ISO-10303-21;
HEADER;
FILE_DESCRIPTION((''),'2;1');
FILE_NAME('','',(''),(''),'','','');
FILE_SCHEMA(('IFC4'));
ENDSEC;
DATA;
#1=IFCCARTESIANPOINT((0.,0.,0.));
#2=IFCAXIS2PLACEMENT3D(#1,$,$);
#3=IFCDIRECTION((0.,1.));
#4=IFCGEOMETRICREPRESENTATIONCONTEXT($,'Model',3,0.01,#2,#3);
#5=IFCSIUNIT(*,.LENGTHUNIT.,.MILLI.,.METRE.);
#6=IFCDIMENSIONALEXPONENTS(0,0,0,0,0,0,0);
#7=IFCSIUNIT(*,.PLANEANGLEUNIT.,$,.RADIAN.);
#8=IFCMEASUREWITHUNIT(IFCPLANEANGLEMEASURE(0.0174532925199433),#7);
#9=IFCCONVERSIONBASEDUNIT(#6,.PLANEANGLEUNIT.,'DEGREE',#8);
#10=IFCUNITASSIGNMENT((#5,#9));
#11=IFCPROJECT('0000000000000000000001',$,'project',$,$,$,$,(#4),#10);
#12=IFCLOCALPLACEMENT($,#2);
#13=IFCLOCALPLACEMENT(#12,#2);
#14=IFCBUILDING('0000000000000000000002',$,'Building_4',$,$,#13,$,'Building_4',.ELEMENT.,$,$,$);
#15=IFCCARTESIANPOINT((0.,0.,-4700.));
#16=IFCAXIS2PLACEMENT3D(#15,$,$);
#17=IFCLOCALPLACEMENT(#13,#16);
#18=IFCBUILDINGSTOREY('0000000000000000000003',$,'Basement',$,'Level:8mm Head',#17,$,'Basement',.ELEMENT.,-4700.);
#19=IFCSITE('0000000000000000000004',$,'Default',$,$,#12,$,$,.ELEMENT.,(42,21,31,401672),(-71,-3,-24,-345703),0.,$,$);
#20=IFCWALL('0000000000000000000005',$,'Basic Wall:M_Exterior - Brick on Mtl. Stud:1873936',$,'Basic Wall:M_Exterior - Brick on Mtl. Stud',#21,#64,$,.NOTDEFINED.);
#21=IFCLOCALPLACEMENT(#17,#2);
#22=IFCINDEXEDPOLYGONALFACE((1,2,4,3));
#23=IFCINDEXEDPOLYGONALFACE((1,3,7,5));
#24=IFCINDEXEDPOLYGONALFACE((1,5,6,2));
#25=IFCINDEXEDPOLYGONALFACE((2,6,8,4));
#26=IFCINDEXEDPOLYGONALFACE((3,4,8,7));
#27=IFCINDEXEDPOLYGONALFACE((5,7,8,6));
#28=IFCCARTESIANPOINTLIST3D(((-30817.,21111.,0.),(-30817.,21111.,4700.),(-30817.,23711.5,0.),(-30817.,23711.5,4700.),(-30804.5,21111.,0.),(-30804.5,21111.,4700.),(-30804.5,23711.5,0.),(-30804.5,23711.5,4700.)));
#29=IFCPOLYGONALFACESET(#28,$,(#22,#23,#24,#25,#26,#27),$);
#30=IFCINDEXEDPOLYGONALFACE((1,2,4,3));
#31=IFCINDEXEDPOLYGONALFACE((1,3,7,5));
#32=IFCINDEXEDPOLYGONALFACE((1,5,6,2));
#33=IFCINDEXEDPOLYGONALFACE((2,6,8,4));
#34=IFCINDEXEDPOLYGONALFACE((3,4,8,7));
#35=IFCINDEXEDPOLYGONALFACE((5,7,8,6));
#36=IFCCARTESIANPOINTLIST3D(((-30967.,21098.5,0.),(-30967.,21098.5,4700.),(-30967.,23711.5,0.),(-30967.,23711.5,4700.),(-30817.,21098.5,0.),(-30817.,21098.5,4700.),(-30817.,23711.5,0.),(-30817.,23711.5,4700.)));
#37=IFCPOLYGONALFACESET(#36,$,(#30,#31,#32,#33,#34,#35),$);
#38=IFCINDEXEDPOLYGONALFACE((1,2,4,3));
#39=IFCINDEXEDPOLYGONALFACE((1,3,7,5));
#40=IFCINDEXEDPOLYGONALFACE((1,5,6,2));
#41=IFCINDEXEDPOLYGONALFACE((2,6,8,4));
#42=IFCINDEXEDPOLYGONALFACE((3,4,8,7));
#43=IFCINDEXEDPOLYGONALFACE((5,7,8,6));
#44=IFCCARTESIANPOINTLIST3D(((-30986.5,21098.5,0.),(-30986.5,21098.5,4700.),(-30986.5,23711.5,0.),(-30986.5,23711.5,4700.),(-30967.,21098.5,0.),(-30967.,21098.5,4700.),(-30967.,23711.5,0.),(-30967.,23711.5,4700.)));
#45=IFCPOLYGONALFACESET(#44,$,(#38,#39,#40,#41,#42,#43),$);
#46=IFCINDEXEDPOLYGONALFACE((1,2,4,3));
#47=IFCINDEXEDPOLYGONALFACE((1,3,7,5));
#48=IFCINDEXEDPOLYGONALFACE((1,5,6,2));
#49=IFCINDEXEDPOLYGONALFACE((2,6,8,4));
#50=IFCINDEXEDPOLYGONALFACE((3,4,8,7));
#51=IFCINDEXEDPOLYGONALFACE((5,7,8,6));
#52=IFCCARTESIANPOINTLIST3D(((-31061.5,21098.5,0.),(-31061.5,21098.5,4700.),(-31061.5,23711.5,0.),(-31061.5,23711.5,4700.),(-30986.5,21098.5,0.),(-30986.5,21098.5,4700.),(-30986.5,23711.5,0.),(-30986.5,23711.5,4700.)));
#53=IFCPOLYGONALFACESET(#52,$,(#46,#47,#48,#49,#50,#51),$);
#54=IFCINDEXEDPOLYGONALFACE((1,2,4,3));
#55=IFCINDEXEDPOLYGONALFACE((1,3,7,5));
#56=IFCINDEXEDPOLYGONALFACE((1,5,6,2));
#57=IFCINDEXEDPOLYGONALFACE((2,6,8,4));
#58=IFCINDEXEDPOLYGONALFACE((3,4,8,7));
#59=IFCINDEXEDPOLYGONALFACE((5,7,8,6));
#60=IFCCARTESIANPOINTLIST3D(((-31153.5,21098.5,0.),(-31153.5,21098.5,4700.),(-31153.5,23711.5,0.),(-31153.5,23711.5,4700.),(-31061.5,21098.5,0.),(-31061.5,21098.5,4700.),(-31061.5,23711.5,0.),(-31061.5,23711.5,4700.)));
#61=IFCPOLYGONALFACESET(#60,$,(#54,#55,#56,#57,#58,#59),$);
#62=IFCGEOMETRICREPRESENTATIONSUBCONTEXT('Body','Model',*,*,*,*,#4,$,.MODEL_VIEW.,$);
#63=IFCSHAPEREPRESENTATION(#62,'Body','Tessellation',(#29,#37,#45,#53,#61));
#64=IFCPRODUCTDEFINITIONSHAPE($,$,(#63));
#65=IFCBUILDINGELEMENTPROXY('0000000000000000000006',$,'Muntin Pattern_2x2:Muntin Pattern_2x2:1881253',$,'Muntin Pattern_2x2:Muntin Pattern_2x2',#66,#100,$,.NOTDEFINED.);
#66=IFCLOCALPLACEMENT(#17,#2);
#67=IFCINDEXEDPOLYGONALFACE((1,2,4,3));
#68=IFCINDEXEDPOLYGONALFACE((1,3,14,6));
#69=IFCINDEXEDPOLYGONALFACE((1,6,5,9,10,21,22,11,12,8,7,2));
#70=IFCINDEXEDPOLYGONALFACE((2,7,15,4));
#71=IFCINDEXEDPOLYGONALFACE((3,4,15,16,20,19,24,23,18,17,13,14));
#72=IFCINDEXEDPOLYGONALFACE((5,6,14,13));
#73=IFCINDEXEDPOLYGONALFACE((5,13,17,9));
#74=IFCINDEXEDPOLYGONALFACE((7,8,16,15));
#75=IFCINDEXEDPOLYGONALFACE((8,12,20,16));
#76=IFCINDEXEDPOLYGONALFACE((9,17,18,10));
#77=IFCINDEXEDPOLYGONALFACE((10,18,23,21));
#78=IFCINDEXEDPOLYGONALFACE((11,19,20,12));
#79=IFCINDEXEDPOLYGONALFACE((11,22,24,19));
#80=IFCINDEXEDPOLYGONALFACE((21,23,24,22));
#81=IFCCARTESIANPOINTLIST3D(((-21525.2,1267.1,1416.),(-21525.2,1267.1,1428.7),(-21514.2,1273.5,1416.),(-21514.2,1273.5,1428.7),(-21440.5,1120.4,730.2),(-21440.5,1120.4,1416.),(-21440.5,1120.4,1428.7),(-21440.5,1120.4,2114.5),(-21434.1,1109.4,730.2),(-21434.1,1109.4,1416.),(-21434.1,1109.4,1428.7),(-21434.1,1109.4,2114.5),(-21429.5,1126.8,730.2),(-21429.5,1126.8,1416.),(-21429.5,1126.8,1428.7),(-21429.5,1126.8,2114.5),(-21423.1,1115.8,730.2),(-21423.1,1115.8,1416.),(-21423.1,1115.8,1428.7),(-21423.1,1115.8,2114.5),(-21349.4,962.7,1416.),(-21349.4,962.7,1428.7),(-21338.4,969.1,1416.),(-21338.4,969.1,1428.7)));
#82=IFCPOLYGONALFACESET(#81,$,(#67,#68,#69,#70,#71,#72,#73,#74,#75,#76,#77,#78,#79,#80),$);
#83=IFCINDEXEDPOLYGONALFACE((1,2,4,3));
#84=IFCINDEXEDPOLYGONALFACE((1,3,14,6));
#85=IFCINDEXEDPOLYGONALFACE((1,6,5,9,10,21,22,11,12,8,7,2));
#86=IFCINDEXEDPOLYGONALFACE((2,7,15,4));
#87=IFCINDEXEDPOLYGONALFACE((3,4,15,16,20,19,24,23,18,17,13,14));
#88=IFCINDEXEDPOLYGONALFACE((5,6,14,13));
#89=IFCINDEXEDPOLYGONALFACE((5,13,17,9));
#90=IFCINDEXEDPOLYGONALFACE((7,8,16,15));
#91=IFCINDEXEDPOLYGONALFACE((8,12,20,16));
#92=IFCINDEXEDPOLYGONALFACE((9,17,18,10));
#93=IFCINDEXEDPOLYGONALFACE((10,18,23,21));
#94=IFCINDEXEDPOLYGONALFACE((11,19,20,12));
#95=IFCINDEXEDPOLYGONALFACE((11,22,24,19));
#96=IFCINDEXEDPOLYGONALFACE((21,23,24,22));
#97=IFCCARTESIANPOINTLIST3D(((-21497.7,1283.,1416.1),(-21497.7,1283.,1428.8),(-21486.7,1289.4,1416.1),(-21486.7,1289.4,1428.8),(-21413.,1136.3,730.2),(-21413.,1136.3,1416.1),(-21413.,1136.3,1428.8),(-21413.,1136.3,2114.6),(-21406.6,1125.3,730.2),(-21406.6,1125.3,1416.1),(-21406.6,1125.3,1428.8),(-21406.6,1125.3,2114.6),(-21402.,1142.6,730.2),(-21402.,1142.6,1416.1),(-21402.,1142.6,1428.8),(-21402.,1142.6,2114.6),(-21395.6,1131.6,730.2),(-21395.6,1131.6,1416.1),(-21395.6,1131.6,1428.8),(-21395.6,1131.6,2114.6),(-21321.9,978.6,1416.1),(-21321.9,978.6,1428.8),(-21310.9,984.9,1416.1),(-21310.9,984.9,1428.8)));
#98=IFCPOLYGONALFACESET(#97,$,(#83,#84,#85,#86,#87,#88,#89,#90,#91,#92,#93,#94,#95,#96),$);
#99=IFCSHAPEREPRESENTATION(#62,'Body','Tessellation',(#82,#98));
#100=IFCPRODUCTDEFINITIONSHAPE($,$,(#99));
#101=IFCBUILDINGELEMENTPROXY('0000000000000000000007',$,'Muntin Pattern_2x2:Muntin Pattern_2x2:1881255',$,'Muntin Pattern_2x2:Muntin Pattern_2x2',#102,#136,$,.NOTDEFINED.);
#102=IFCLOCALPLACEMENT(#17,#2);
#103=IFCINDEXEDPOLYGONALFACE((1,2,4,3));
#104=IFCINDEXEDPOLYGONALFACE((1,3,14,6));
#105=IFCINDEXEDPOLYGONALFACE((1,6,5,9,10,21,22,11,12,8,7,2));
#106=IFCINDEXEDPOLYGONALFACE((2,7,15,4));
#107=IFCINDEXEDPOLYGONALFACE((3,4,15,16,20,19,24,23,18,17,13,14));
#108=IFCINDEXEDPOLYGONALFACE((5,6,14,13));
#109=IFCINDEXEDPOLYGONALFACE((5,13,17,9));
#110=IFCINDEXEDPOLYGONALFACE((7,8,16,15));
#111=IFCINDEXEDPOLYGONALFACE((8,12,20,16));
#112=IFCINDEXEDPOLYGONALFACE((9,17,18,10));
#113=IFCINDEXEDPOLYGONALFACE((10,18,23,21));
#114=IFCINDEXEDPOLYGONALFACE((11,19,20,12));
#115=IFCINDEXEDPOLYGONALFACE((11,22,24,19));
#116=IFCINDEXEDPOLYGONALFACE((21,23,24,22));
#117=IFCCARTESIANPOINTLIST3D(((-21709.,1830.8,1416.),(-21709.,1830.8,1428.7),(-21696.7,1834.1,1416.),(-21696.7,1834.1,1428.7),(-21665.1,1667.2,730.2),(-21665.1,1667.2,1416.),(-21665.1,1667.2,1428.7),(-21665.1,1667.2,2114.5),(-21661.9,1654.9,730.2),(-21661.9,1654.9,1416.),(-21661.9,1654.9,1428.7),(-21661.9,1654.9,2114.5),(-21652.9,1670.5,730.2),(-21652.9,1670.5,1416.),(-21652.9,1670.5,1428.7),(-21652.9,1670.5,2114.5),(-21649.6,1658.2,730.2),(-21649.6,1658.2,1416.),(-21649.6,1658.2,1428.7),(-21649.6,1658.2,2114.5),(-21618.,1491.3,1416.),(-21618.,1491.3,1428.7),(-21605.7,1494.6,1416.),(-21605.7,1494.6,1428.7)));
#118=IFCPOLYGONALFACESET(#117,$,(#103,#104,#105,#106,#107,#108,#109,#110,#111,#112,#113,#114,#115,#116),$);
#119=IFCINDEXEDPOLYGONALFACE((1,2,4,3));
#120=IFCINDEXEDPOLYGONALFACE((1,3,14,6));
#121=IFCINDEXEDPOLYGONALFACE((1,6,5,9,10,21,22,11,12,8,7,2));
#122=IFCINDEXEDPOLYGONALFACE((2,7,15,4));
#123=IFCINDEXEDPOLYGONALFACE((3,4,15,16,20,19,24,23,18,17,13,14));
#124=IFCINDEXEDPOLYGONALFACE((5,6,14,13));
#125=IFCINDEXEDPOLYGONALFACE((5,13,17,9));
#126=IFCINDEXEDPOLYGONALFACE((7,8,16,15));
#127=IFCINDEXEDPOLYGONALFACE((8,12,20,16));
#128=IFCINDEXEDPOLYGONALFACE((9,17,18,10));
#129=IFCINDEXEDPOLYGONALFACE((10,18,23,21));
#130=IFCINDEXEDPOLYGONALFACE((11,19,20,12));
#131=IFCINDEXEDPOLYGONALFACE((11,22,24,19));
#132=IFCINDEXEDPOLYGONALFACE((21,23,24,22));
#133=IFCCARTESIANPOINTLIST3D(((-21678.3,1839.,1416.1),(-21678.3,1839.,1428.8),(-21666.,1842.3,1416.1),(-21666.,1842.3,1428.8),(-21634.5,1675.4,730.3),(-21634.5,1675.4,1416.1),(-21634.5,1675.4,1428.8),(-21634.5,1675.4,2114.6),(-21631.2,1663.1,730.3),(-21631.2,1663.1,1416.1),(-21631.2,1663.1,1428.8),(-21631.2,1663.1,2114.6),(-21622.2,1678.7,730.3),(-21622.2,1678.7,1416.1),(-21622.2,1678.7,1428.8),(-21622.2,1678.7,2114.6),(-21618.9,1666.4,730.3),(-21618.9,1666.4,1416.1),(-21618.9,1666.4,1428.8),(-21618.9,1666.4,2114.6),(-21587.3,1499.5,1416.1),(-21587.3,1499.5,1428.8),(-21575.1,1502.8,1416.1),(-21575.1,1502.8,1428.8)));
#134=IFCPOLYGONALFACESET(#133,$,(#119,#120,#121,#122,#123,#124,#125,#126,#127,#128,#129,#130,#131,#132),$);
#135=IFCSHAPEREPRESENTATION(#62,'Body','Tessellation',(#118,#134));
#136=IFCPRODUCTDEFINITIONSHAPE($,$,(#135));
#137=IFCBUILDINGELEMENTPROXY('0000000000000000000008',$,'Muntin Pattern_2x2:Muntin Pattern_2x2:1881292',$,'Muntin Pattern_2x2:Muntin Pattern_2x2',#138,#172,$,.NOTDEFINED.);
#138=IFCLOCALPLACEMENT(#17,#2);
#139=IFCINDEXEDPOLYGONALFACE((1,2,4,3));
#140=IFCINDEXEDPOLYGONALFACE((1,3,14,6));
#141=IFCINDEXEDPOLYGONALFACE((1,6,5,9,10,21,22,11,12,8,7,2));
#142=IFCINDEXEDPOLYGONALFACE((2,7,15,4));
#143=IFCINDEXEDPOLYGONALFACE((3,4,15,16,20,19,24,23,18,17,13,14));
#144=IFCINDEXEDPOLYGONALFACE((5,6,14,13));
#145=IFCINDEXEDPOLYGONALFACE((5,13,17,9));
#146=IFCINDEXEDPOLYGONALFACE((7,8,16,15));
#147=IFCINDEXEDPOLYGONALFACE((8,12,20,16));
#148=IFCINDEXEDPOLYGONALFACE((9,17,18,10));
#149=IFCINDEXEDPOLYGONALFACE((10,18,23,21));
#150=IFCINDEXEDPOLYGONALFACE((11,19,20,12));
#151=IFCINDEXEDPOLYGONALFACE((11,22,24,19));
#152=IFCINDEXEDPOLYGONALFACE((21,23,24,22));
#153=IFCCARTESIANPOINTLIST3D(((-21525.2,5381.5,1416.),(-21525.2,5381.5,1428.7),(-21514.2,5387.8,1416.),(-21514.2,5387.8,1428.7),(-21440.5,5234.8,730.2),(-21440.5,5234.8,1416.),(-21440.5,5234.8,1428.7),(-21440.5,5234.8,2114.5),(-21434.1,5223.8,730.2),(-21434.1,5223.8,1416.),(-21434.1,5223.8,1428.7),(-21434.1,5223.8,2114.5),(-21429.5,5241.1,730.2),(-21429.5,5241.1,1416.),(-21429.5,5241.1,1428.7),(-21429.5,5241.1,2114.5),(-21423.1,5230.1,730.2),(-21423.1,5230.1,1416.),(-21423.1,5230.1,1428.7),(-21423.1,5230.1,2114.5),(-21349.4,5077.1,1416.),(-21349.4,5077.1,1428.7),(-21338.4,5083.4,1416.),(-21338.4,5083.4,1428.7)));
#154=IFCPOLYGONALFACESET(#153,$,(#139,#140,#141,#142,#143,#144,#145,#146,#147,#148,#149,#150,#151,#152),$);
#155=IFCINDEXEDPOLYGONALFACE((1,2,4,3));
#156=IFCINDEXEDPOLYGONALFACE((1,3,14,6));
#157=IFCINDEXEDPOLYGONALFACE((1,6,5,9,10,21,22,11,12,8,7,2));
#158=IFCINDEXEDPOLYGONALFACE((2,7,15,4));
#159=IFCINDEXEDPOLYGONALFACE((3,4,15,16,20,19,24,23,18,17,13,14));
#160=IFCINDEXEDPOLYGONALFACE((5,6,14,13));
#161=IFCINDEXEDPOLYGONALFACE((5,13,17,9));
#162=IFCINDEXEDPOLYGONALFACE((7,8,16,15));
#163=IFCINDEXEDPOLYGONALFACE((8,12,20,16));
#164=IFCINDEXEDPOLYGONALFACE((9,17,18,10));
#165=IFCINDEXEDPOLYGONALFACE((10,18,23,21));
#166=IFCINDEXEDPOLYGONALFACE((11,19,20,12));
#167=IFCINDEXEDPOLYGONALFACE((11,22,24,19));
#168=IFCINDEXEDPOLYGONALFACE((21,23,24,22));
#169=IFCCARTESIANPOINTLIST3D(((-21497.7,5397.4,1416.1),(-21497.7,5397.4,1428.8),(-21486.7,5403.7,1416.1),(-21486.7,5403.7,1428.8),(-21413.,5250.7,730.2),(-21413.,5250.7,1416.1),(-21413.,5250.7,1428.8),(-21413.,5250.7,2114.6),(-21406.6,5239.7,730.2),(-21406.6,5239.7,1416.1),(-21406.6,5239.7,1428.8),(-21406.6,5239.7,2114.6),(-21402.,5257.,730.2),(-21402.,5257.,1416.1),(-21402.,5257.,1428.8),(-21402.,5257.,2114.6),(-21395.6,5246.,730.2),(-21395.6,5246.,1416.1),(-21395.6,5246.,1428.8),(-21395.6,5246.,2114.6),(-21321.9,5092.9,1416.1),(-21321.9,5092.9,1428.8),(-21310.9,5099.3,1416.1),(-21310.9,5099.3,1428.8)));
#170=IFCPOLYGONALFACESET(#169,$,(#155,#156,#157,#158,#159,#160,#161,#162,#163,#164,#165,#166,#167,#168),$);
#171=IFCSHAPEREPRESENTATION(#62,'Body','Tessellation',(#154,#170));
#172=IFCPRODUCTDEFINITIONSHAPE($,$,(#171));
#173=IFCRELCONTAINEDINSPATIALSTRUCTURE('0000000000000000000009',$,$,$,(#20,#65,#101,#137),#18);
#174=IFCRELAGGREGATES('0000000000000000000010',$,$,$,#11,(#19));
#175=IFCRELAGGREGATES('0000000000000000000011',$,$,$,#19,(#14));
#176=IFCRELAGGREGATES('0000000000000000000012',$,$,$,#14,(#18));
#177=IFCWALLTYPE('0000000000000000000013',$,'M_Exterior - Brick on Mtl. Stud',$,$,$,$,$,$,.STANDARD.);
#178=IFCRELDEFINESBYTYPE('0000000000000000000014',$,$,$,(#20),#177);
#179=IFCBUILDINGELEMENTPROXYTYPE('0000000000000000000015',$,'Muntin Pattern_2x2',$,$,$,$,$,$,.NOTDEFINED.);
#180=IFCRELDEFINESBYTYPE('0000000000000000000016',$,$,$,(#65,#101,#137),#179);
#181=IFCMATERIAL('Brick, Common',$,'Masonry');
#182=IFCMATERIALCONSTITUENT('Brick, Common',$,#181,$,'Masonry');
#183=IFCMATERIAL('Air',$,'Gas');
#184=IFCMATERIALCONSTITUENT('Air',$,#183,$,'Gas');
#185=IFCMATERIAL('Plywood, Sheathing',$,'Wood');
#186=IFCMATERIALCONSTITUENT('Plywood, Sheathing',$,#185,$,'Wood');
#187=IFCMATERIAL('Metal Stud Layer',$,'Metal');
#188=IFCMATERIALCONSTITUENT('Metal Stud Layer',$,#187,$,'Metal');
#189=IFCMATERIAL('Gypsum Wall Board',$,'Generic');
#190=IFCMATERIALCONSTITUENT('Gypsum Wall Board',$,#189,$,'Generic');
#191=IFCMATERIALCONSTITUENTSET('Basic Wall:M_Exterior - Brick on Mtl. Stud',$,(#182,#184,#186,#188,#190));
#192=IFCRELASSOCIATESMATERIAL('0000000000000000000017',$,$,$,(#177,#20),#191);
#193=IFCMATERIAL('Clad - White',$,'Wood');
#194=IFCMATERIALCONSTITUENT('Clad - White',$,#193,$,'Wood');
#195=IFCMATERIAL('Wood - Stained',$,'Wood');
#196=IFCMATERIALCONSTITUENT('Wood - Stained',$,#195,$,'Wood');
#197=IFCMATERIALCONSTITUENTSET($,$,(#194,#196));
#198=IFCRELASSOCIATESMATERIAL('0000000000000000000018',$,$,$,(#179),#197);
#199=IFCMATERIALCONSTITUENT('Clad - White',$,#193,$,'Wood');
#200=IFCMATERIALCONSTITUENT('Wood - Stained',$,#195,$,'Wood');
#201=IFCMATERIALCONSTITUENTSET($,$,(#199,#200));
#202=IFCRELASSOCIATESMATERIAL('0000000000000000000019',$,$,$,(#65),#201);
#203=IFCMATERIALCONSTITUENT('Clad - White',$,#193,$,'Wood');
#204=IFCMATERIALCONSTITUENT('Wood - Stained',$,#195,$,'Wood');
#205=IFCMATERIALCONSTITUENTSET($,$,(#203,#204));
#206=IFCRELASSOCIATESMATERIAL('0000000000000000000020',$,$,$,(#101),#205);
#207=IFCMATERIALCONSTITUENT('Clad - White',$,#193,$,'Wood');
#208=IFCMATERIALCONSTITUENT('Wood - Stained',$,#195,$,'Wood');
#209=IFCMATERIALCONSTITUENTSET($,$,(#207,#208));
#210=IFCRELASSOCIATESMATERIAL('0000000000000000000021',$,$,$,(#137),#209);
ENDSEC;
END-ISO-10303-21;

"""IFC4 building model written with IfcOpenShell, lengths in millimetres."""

from ifc_helpers import new_model, entity, si_unit, converted_unit, direction, frame, origin, place, context, subcontext, project, spatial, indexed_curve, outline, extrude, source, transform, mapped, material, constituent, constituent_set, type_object, type_shapes, element, save


model = new_model("IFC4")

# Units and contexts
model_context = context("Model", 3, precision=0.01, world=origin(), true_north=direction((0.0, 1.0)))
body_context = subcontext(model_context, "Body", "Model", "MODEL_VIEW")
ifc_project = project(units=[si_unit("LENGTHUNIT", "METRE", prefix="MILLI"), converted_unit("PLANEANGLEUNIT", "DEGREE", entity("IfcPlaneAngleMeasure", 0.0174532925199433), si_unit("PLANEANGLEUNIT", "RADIAN"), dimensions=[0, 0, 0, 0, 0, 0, 0])], contexts=[model_context])

# Site, building, storey
site_placement = place(None, origin())
site = spatial("IfcSite", under=ifc_project, at=site_placement, Name="Default", CompositionType="ELEMENT", RefLatitude=(42, 21, 31, 401672), RefLongitude=(-71, -3, -24, -345703), RefElevation=0.0)
building_placement = place(site_placement, origin())
building = spatial("IfcBuilding", under=site, at=building_placement, Name="Building_4", LongName="Building_4", CompositionType="ELEMENT")
storey_placement = place(building_placement, frame((0.0, 0.0, -4700.0)))
storey = spatial("IfcBuildingStorey", under=building, at=storey_placement, Name="Basement", ObjectType="Level:8mm Head", LongName="Basement", CompositionType="ELEMENT", Elevation=-4700.0)

# Wall
ifc_material_1 = material(Name="Brick, Common", Category="Masonry")
ifc_constituent_1 = constituent(ifc_material_1, Name="Brick, Common", Category="Masonry")
ifc_material_2 = material(Name="Air", Category="Gas")
ifc_constituent_2 = constituent(ifc_material_2, Name="Air", Category="Gas")
ifc_material_3 = material(Name="Plywood, Sheathing", Category="Wood")
ifc_constituent_3 = constituent(ifc_material_3, Name="Plywood, Sheathing", Category="Wood")
ifc_material_4 = material(Name="Metal Stud Layer", Category="Metal")
ifc_constituent_4 = constituent(ifc_material_4, Name="Metal Stud Layer", Category="Metal")
ifc_material_5 = material(Name="Gypsum Wall Board", Category="Generic")
ifc_constituent_5 = constituent(ifc_material_5, Name="Gypsum Wall Board", Category="Generic")
ifc_constituent_set_1 = constituent_set(constituents=[ifc_constituent_1, ifc_constituent_2, ifc_constituent_3, ifc_constituent_4, ifc_constituent_5], Name="Basic Wall:M_Exterior - Brick on Mtl. Stud")
wall_type = type_object("IfcWallType", Name="M_Exterior - Brick on Mtl. Stud", PredefinedType="STANDARD", material=ifc_constituent_set_1)
wall_placement = place(storey_placement, frame((-30979.0, 21111.0, 0.0), z_axis=(0.0, 0.0, 1.0), x_axis=(0.0, 1.0, 0.0)))
element("IfcWall", 1, at=wall_placement, inside=storey, type_object=wall_type, material=ifc_constituent_set_1, Name="Basic Wall:M_Exterior - Brick on Mtl. Stud:1873936", ObjectType="Basic Wall:M_Exterior - Brick on Mtl. Stud", PredefinedType="NOTDEFINED", context=body_context, shape_type="SweptSolid", body=[
    extrude(outline(indexed_curve([(-6.3, -1300.2), (6.2, -1300.2), (6.2, 1300.2), (-6.2, 1300.2), (-6.3, -1300.2)], self_intersect=False)), frame((1300.2, -168.2, 0.0), z_axis=(0.0, 0.0, 1.0), x_axis=(0.0, 1.0, 0.0)), (0.0, 0.0, 1.0), 4700.0),
    extrude(outline(indexed_curve([(-1306.5, -75.0), (1306.5, -75.0), (1306.5, 75.0), (-1306.5, 75.0), (-1306.5, -75.0)], self_intersect=False)), frame((1294.0, -87.0, 0.0)), (0.0, 0.0, 1.0), 4700.0),
    extrude(outline(indexed_curve([(-1306.5, -9.7), (1306.5, -9.7), (1306.5, 9.7), (-1306.5, 9.7), (-1306.5, -9.7)], self_intersect=False)), frame((1294.0, -2.3, 0.0)), (0.0, 0.0, 1.0), 4700.0),
    extrude(outline(indexed_curve([(-1306.5, -37.5), (1306.5, -37.5), (1306.5, 37.5), (-1306.5, 37.5), (-1306.5, -37.5)], self_intersect=False)), frame((1294.0, 45.0, 0.0)), (0.0, 0.0, 1.0), 4700.0),
    extrude(outline(indexed_curve([(-46.0, -1306.5), (46.0, -1306.5), (46.0, 1306.5), (-46.0, 1306.5), (-46.0, -1306.5)], self_intersect=False)), frame((1294.0, 128.5, 0.0), z_axis=(0.0, 0.0, 1.0), x_axis=(0.0, -1.0, 0.0)), (0.0, 0.0, 1.0), 4700.0),
])

# Building element proxies
ifc_material_6 = material(Name="Clad - White", Category="Wood")
ifc_constituent_6 = constituent(ifc_material_6, Name="Clad - White", Category="Wood")
ifc_material_7 = material(Name="Wood - Stained", Category="Wood")
ifc_constituent_7 = constituent(ifc_material_7, Name="Wood - Stained", Category="Wood")
ifc_constituent_set_2 = constituent_set(constituents=[ifc_constituent_6, ifc_constituent_7])
ifc_constituent_8 = constituent(ifc_material_6, Name="Clad - White", Category="Wood")
ifc_constituent_9 = constituent(ifc_material_7, Name="Wood - Stained", Category="Wood")
ifc_constituent_set_3 = constituent_set(constituents=[ifc_constituent_8, ifc_constituent_9])
building_element_proxy_type_1 = type_object("IfcBuildingElementProxyType", Name="Muntin Pattern_2x2", PredefinedType="NOTDEFINED", material=ifc_constituent_set_3)
shared_shape_1 = source(origin(), body_context, "Body", "SweptSolid", [
    extrude(outline(indexed_curve([(6.4, -6.4), (692.1, -6.4), (692.1, 6.3), (6.4, 6.3), (6.4, 175.8), (-6.3, 175.8), (-6.3, 6.3), (-692.2, 6.3), (-692.2, -6.4), (-6.3, -6.4), (-6.3, -175.8), (6.4, -175.8), (6.4, -6.4)], self_intersect=False)), frame((0.0, 9.5, 692.1), z_axis=(0.0, 1.0, 0.0), x_axis=(0.0, 0.0, 1.0)), (0.0, 0.0, 1.0), 12.7),
    extrude(outline(indexed_curve([(6.4, -6.4), (692.1, -6.4), (692.1, 6.3), (6.4, 6.3), (6.4, 175.8), (-6.3, 175.8), (-6.3, 6.3), (-692.2, 6.3), (-692.2, -6.4), (-6.3, -6.4), (-6.3, -175.8), (6.4, -175.8), (6.4, -6.4)], self_intersect=False)), frame((0.0, -22.2, 692.2), z_axis=(0.0, 1.0, 0.0), x_axis=(0.0, 0.0, 1.0)), (0.0, 0.0, 1.0), 12.7),
])
type_shapes(building_element_proxy_type_1, [shared_shape_1])
proxy_1_placement = place(storey_placement, frame((-21418.0, 1126.0, 730.2), z_axis=(0.0, 0.0, 1.0), x_axis=(-0.5, 0.866025, 0.0)))
element("IfcBuildingElementProxy", 2, at=proxy_1_placement, inside=storey, type_object=building_element_proxy_type_1, material=ifc_constituent_set_2, Name="Muntin Pattern_2x2:Muntin Pattern_2x2:1881253", ObjectType="Muntin Pattern_2x2:Muntin Pattern_2x2", PredefinedType="NOTDEFINED", context=body_context, shape_type="MappedRepresentation", body=[
    mapped(shared_shape_1, transform((0.0, 0.0, 0.0), scale=1.0)),
])
ifc_constituent_10 = constituent(ifc_material_6, Name="Clad - White", Category="Wood")
ifc_constituent_11 = constituent(ifc_material_7, Name="Wood - Stained", Category="Wood")
ifc_constituent_set_4 = constituent_set(constituents=[ifc_constituent_10, ifc_constituent_11])
proxy_2_placement = place(storey_placement, frame((-21642.0, 1666.8, 730.3), z_axis=(0.0, 0.0, 1.0), x_axis=(-0.258819, 0.965926, 0.0)))
element("IfcBuildingElementProxy", 3, at=proxy_2_placement, inside=storey, type_object=building_element_proxy_type_1, material=ifc_constituent_set_4, Name="Muntin Pattern_2x2:Muntin Pattern_2x2:1881255", ObjectType="Muntin Pattern_2x2:Muntin Pattern_2x2", PredefinedType="NOTDEFINED", context=body_context, shape_type="MappedRepresentation", body=[
    mapped(shared_shape_1, transform((0.0, 0.0, 0.0), scale=1.0)),
])
ifc_constituent_12 = constituent(ifc_material_6, Name="Clad - White", Category="Wood")
ifc_constituent_13 = constituent(ifc_material_7, Name="Wood - Stained", Category="Wood")
ifc_constituent_set_5 = constituent_set(constituents=[ifc_constituent_12, ifc_constituent_13])
proxy_3_placement = place(storey_placement, frame((-21418.0, 5240.4, 730.2), z_axis=(0.0, 0.0, 1.0), x_axis=(-0.5, 0.866025, 0.0)))
element("IfcBuildingElementProxy", 4, at=proxy_3_placement, inside=storey, type_object=building_element_proxy_type_1, material=ifc_constituent_set_5, Name="Muntin Pattern_2x2:Muntin Pattern_2x2:1881292", ObjectType="Muntin Pattern_2x2:Muntin Pattern_2x2", PredefinedType="NOTDEFINED", context=body_context, shape_type="MappedRepresentation", body=[
    mapped(shared_shape_1, transform((0.0, 0.0, 0.0), scale=1.0)),
])

save(model, "model.ifc")
